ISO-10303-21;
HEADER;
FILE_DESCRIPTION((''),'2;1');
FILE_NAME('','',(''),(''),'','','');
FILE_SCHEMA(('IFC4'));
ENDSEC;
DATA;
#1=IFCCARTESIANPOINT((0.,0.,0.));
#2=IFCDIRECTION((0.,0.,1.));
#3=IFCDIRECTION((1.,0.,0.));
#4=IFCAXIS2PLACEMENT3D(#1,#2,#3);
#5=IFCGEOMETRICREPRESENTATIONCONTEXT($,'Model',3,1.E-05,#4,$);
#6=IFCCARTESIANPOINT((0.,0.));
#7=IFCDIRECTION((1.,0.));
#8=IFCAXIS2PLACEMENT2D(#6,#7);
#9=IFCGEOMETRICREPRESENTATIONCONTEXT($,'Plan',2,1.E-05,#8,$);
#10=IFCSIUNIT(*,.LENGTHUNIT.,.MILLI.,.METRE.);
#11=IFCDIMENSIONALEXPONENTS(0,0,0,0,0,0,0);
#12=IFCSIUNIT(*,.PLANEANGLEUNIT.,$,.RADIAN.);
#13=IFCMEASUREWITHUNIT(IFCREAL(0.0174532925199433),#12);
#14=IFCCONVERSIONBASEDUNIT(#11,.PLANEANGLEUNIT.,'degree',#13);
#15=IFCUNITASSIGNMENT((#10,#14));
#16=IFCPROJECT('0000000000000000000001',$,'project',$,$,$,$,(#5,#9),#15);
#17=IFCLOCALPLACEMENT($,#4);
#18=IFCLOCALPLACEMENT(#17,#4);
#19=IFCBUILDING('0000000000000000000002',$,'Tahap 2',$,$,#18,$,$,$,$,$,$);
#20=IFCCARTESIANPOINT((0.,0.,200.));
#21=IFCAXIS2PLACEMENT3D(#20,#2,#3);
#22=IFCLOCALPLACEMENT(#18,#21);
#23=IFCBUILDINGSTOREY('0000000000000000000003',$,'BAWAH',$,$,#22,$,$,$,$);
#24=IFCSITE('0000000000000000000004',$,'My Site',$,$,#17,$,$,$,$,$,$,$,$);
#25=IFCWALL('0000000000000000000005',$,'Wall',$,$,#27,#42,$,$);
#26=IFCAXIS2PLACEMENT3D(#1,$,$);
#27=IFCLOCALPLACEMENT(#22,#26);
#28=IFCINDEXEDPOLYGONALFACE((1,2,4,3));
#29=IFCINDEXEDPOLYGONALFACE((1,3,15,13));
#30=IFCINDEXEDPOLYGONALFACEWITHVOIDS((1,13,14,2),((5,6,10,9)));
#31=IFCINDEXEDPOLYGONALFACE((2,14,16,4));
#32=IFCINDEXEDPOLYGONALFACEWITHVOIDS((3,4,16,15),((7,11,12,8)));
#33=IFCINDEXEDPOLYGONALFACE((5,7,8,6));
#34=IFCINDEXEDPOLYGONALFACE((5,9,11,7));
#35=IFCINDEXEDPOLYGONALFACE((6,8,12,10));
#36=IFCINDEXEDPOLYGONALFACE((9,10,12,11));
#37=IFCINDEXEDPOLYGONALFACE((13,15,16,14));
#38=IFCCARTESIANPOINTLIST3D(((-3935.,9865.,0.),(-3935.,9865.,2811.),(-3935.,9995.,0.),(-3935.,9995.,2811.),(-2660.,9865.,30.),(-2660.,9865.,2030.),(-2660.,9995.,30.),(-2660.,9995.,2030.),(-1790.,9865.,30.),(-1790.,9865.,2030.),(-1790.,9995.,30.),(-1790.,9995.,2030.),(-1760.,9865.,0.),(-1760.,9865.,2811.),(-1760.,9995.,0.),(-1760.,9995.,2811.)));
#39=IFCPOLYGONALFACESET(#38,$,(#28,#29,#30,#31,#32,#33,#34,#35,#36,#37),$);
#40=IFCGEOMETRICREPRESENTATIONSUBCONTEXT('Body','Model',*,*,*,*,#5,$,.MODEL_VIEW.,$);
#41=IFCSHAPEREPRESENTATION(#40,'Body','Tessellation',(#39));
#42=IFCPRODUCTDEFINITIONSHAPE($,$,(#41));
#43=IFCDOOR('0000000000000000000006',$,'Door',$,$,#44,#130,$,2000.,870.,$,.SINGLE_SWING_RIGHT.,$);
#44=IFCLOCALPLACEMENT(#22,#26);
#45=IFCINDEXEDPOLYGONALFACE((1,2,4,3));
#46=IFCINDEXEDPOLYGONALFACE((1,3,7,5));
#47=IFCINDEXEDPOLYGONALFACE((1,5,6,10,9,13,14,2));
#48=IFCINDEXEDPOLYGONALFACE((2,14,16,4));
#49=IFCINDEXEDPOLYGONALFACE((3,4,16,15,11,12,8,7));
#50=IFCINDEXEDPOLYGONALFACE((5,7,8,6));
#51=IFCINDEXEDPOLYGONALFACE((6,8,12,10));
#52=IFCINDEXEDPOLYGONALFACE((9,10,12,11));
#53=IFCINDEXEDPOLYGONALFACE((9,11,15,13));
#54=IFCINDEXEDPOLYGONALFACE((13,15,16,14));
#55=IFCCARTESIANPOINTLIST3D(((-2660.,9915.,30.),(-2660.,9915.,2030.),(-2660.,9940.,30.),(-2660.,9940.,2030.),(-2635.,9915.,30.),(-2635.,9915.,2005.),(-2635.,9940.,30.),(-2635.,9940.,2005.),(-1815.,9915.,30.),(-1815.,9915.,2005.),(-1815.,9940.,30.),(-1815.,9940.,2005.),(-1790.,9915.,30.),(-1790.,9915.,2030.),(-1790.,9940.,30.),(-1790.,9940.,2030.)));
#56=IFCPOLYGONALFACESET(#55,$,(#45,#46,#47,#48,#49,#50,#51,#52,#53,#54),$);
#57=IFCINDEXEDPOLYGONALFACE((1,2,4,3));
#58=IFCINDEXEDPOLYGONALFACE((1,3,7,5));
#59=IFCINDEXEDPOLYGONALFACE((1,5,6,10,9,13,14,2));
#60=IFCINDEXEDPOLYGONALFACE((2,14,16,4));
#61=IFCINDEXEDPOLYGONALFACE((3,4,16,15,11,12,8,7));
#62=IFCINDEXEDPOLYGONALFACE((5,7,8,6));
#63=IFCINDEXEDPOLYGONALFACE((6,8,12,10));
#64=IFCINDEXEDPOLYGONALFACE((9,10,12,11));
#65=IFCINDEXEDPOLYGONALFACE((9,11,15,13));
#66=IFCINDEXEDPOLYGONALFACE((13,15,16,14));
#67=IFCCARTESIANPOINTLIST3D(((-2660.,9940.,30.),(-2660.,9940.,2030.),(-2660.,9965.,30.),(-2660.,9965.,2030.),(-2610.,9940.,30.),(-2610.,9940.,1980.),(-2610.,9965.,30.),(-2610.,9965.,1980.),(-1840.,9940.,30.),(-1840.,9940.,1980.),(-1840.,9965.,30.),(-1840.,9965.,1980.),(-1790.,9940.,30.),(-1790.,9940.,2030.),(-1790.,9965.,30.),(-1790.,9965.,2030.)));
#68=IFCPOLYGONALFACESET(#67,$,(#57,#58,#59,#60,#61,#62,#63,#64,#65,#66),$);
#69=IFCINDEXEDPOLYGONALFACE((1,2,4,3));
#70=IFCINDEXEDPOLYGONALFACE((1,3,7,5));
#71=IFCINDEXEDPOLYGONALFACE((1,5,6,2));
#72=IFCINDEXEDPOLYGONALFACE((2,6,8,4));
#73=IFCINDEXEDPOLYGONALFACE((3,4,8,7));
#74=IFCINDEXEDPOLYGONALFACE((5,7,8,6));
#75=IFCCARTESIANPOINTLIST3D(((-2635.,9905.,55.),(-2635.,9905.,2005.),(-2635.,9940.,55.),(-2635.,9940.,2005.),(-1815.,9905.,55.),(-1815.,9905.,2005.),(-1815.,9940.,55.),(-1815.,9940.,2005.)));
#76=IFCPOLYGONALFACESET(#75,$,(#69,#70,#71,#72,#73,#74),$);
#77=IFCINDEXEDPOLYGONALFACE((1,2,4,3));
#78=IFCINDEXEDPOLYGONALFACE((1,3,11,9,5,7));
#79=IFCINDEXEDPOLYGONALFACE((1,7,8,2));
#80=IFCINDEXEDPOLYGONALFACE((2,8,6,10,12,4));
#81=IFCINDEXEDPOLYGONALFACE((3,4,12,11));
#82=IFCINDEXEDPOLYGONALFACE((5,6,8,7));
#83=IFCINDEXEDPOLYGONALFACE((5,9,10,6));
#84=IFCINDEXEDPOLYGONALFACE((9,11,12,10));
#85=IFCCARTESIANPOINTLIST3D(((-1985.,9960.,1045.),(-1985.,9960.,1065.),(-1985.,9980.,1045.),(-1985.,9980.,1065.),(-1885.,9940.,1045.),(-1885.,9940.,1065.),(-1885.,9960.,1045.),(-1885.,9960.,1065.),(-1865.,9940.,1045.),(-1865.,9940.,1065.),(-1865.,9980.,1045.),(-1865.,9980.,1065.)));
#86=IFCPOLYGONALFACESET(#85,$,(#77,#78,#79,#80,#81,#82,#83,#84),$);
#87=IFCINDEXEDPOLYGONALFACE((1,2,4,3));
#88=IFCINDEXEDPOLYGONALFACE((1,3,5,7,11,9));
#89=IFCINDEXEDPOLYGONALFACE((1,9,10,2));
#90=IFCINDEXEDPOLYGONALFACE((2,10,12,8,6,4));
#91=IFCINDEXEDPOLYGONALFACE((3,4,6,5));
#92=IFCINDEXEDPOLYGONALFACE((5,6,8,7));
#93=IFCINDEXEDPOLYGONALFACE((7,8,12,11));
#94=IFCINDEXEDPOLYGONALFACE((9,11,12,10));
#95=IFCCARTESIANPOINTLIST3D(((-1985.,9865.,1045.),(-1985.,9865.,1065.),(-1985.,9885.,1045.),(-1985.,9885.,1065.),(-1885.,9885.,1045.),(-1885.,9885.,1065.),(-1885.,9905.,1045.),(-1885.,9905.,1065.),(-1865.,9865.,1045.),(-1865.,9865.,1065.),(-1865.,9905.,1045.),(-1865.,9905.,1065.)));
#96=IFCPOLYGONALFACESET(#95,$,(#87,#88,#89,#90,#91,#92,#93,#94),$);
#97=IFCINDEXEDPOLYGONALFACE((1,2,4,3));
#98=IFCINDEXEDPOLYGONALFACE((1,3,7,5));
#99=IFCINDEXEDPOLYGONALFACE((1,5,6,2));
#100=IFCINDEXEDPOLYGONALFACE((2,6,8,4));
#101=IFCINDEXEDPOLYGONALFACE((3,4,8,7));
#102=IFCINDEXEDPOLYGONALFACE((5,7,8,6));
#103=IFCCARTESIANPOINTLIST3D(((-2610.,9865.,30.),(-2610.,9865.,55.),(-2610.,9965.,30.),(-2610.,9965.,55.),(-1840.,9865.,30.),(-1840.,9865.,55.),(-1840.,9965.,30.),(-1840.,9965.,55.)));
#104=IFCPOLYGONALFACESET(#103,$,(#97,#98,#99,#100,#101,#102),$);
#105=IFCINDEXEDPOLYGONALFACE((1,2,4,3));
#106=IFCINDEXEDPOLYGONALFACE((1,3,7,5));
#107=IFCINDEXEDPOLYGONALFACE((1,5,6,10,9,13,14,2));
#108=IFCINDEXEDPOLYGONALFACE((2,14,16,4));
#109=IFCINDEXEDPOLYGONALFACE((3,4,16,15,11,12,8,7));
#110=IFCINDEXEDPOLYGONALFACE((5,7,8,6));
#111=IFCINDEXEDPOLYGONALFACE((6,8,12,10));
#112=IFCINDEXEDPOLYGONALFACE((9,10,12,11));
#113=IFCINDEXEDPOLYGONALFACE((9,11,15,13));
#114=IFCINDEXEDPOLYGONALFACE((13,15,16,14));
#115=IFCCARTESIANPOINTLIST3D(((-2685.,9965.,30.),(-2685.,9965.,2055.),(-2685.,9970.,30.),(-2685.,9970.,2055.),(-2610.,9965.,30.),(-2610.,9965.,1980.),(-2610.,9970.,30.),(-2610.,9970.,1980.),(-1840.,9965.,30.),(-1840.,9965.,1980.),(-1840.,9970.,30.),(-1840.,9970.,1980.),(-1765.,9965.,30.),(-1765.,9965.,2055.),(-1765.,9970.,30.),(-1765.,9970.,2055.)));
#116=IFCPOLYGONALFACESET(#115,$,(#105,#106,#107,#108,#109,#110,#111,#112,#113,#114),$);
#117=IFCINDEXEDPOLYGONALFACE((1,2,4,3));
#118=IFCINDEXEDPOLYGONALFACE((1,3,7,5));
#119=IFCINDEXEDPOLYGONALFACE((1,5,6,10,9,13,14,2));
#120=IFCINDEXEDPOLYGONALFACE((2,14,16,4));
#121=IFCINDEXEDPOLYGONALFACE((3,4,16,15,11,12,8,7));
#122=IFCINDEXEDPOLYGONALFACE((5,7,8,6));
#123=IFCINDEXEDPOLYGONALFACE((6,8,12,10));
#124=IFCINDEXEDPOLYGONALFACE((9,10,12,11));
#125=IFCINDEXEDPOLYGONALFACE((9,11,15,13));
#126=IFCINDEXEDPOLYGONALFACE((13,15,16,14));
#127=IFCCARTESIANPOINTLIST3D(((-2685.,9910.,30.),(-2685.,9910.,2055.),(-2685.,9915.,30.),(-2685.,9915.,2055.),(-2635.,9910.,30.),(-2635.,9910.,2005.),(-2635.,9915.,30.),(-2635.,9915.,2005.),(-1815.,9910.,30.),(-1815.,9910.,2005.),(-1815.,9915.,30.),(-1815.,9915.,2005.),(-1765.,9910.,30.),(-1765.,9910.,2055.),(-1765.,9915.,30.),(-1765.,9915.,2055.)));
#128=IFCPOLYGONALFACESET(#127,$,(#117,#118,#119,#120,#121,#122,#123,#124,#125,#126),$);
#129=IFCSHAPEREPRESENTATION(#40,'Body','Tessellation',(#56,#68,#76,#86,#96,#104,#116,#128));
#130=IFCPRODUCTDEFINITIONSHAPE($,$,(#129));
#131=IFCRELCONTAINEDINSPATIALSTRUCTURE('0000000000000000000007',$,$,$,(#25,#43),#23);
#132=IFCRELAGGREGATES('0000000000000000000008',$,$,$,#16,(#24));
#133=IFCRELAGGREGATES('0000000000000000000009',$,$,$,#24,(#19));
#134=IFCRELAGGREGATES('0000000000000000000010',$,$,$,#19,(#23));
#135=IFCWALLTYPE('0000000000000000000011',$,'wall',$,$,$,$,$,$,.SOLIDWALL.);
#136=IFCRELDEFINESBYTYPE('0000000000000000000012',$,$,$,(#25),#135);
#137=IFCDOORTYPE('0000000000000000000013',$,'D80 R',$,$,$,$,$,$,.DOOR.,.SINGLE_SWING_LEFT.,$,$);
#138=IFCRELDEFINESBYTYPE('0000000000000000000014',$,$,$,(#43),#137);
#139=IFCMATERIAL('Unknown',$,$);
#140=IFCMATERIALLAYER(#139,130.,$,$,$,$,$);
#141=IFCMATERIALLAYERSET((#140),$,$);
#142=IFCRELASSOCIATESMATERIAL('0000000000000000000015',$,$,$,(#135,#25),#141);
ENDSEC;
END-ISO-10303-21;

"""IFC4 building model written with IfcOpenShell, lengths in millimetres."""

from ifc_helpers import new_model, entity, si_unit, converted_unit, frame, origin_with_axes, origin_2d_with_axis, place, context, subcontext, project, spatial, line, indexed_curve, outline, extrude, shape, source, transform, mapped, material, layer, layer_set, layer_usage, type_object, type_shapes, element, fill, save


model = new_model("IFC4")

# Units and contexts
model_context = context("Model", 3, precision=1e-05, world=origin_with_axes())
plan_context = context("Plan", 2, precision=1e-05, world=origin_2d_with_axis())
body_context_1 = subcontext(model_context, "Body", "Model", "MODEL_VIEW")
body_context_2 = subcontext(plan_context, "Body", "Plan", "PLAN_VIEW")
ifc_project = project(units=[si_unit("LENGTHUNIT", "METRE", prefix="MILLI"), converted_unit("PLANEANGLEUNIT", "degree", entity("IfcReal", 0.0174532925199433), si_unit("PLANEANGLEUNIT", "RADIAN"), dimensions=[0, 0, 0, 0, 0, 0, 0])], contexts=[model_context, plan_context])

# Site, building, storey
site_placement = place(None, origin_with_axes())
site = spatial("IfcSite", under=ifc_project, at=site_placement, Name="My Site")
building_placement = place(site_placement, origin_with_axes())
building = spatial("IfcBuilding", under=site, at=building_placement, Name="Tahap 2")
storey_placement = place(building_placement, frame((0.0, 0.0, 200.0), z_axis=(0.0, 0.0, 1.0), x_axis=(1.0, 0.0, 0.0)))
storey = spatial("IfcBuildingStorey", under=building, at=storey_placement, Name="BAWAH")

# Shared definitions
ifc_material_1 = material(Name="Unknown")
ifc_layer_1 = layer(ifc_material_1, 130.0)
ifc_layer_set_1 = layer_set([ifc_layer_1])
wall_type = type_object("IfcWallType", Name="wall", PredefinedType="SOLIDWALL", material=ifc_layer_set_1)

# Wall, opening, door
ifc_layer_usage_1 = layer_usage(ifc_layer_set_1, "AXIS2", "NEGATIVE", 0.0)
wall_1_placement = place(storey_placement, frame((-3935.0, 9995.0, 0.0), z_axis=(0.0, 0.0, 1.0), x_axis=(1.0, 0.0, 0.0)))
wall_1 = element("IfcWall", 1, at=wall_1_placement, inside=storey, type_object=wall_type, material=ifc_layer_usage_1, Name="Wall", context=body_context_1, shape_type="SweptSolid", body=[
    extrude(outline(indexed_curve([(0.0, -130.0), (0.0, 0.0), (2175.0, 0.0), (2175.0, -130.0)], segments=[line(1, 2, 3, 4, 1)])), origin_with_axes(), (0.0, 0.0, 1.0), 2811.0),
])
shared_shape_1 = source(origin_with_axes(), body_context_1, "Body", "SweptSolid", [
    extrude(outline(indexed_curve([(0.0, 0.0), (870.0, 0.0), (870.0, 2000.0), (0.0, 2000.0)], segments=[line(1, 2, 3, 4, 1)])), frame((0.0, -600.0, 0.0), z_axis=(0.0, -1.0, 0.0), x_axis=(1.0, 0.0, 0.0)), (0.0, 0.0, -1.0), 1200.0),
])
opening_placement = place(wall_1_placement, frame((2145.0, -30.0, 30.0), z_axis=(0.0, 0.0, 1.0), x_axis=(-1.0, 0.0, 0.0)))
opening = element("IfcOpeningElement", 2, at=opening_placement, cuts=wall_1, PredefinedType="OPENING", context=body_context_1, shape_type="MappedRepresentation", body=[
    mapped(shared_shape_1, transform((0.0, 0.0, 0.0), x_axis=(1.0, 0.0, 0.0), y_axis=(0.0, 1.0, 0.0), z_axis=(0.0, 0.0, 1.0), scale=1.0)),
])
door_type = type_object("IfcDoorType", Name="D80 R", OperationType="SINGLE_SWING_LEFT", PredefinedType="DOOR")
shared_shape_2 = source(origin_with_axes(), body_context_1, "Body", "SweptSolid", [
    extrude(outline(indexed_curve([(0.0, 0.0), (0.0, 2000.0), (870.0, 2000.0), (870.0, 0.0), (845.0, 0.0), (845.0, 1975.0), (25.0, 1975.0), (25.0, 0.0)], segments=[line(1, 2, 3, 4, 5, 6, 7, 8, 1)])), frame((0.0, 25.0, 0.0), z_axis=(0.0, -1.0, 0.0), x_axis=(1.0, 0.0, 0.0)), (0.0, 0.0, -1.0), 25.0),
    extrude(outline(indexed_curve([(0.0, 0.0), (0.0, 2000.0), (870.0, 2000.0), (870.0, 0.0), (820.0, 0.0), (820.0, 1950.0), (50.0, 1950.0), (50.0, 0.0)], segments=[line(1, 2, 3, 4, 5, 6, 7, 8, 1)])), frame((0.0, 0.0, 0.0), z_axis=(0.0, -1.0, 0.0), x_axis=(1.0, 0.0, 0.0)), (0.0, 0.0, -1.0), 25.0),
    extrude(outline(indexed_curve([(0.0, 0.0), (820.0, 0.0), (820.0, 35.0), (0.0, 35.0)], segments=[line(1, 2, 3, 4, 1)])), frame((25.0, 25.0, 25.0), z_axis=(0.0, 0.0, 1.0), x_axis=(1.0, 0.0, 0.0)), (0.0, 0.0, 1.0), 1950.0),
    extrude(outline(indexed_curve([(0.0, 0.0), (0.0, -40.0), (120.0, -40.0), (120.0, -20.0), (20.0, -20.0), (20.0, 0.0)], segments=[line(1, 2, 3, 4, 5, 6, 1)])), frame((75.0, 25.0, 1015.0), z_axis=(0.0, 0.0, 1.0), x_axis=(1.0, 0.0, 0.0)), (0.0, 0.0, 1.0), 20.0),
    extrude(outline(indexed_curve([(0.0, 0.0), (0.0, 40.0), (120.0, 40.0), (120.0, 20.0), (20.0, 20.0), (20.0, 0.0)], segments=[line(1, 2, 3, 4, 5, 6, 1)])), frame((75.0, 60.0, 1015.0), z_axis=(0.0, 0.0, 1.0), x_axis=(1.0, 0.0, 0.0)), (0.0, 0.0, 1.0), 20.0),
    extrude(outline(indexed_curve([(0.0, 0.0), (770.0, 0.0), (770.0, 100.0), (0.0, 100.0)], segments=[line(1, 2, 3, 4, 1)])), frame((50.0, 0.0, 0.0), z_axis=(0.0, 0.0, 1.0), x_axis=(1.0, 0.0, 0.0)), (0.0, 0.0, 1.0), 25.0),
    extrude(outline(indexed_curve([(0.0, 0.0), (0.0, 2025.0), (920.0, 2025.0), (920.0, 0.0), (845.0, 0.0), (845.0, 1950.0), (75.0, 1950.0), (75.0, 0.0)], segments=[line(1, 2, 3, 4, 5, 6, 7, 8, 1)])), frame((-25.0, -5.0, 0.0), z_axis=(0.0, -1.0, 0.0), x_axis=(1.0, 0.0, 0.0)), (0.0, 0.0, -1.0), 5.0),
    extrude(outline(indexed_curve([(0.0, 0.0), (0.0, 2025.0), (920.0, 2025.0), (920.0, 0.0), (870.0, 0.0), (870.0, 1975.0), (50.0, 1975.0), (50.0, 0.0)], segments=[line(1, 2, 3, 4, 5, 6, 7, 8, 1)])), frame((-25.0, 50.0, 0.0), z_axis=(0.0, -1.0, 0.0), x_axis=(1.0, 0.0, 0.0)), (0.0, 0.0, -1.0), 5.0),
])
shared_shape_3 = source(origin_with_axes(), body_context_2, "Body", "Curve2D", [
    entity("IfcIndexedPolyCurve", entity("IfcCartesianPointList2D", [[0.0, 0.0], [0.0, 50.0], [25.0, 50.0], [25.0, 25.0], [50.0, 25.0], [50.0, 0.0]]), [entity("IfcLineIndex", [1, 2, 3, 4, 5, 6, 1])]),
    entity("IfcIndexedPolyCurve", entity("IfcCartesianPointList2D", [[870.0, 0.0], [870.0, 50.0], [845.0, 50.0], [845.0, 25.0], [820.0, 25.0], [820.0, 0.0]]), [entity("IfcLineIndex", [1, 2, 3, 4, 5, 6, 1])]),
    entity("IfcTrimmedCurve", entity("IfcEllipse", entity("IfcAxis2Placement2D", entity("IfcCartesianPoint", [810.0, 50.0]), entity("IfcDirection", [1.0, 0.0])), 785.0, 820.0), [entity("IfcCartesianPoint", [810.0, 870.0])], [entity("IfcCartesianPoint", [25.0, 50.0])], True, "CARTESIAN"),
    entity("IfcIndexedPolyCurve", entity("IfcCartesianPointList2D", [[845.0, 50.0], [810.0, 50.0], [810.0, 870.0], [845.0, 870.0]]), [entity("IfcLineIndex", [1, 2, 3, 4, 1])]),
])
type_shapes(door_type, [shared_shape_2, shared_shape_3])
door_placement = place(opening_placement, frame((0.0, 0.0, 0.0), z_axis=(0.0, 0.0, 1.0), x_axis=(1.0, 0.0, 0.0)))
door = element("IfcDoor", 3, at=door_placement, inside=storey, type_object=door_type, Name="Door", OperationType="SINGLE_SWING_RIGHT", OverallHeight=2000.0, OverallWidth=870.0, shapes=[
    shape(body_context_1, "Body", "MappedRepresentation", [mapped(shared_shape_2, transform((0.0, 0.0, 0.0), x_axis=(1.0, 0.0, 0.0), y_axis=(0.0, 1.0, 0.0), z_axis=(0.0, 0.0, 1.0), scale=1.0))]),
    shape(body_context_2, "Body", "MappedRepresentation", [mapped(shared_shape_3, transform((0.0, 0.0, 0.0), x_axis=(1.0, 0.0, 0.0), y_axis=(0.0, 1.0, 0.0), z_axis=(0.0, 0.0, 1.0), scale=1.0))]),
])
fill(opening, door)

save(model, "model.ifc")
